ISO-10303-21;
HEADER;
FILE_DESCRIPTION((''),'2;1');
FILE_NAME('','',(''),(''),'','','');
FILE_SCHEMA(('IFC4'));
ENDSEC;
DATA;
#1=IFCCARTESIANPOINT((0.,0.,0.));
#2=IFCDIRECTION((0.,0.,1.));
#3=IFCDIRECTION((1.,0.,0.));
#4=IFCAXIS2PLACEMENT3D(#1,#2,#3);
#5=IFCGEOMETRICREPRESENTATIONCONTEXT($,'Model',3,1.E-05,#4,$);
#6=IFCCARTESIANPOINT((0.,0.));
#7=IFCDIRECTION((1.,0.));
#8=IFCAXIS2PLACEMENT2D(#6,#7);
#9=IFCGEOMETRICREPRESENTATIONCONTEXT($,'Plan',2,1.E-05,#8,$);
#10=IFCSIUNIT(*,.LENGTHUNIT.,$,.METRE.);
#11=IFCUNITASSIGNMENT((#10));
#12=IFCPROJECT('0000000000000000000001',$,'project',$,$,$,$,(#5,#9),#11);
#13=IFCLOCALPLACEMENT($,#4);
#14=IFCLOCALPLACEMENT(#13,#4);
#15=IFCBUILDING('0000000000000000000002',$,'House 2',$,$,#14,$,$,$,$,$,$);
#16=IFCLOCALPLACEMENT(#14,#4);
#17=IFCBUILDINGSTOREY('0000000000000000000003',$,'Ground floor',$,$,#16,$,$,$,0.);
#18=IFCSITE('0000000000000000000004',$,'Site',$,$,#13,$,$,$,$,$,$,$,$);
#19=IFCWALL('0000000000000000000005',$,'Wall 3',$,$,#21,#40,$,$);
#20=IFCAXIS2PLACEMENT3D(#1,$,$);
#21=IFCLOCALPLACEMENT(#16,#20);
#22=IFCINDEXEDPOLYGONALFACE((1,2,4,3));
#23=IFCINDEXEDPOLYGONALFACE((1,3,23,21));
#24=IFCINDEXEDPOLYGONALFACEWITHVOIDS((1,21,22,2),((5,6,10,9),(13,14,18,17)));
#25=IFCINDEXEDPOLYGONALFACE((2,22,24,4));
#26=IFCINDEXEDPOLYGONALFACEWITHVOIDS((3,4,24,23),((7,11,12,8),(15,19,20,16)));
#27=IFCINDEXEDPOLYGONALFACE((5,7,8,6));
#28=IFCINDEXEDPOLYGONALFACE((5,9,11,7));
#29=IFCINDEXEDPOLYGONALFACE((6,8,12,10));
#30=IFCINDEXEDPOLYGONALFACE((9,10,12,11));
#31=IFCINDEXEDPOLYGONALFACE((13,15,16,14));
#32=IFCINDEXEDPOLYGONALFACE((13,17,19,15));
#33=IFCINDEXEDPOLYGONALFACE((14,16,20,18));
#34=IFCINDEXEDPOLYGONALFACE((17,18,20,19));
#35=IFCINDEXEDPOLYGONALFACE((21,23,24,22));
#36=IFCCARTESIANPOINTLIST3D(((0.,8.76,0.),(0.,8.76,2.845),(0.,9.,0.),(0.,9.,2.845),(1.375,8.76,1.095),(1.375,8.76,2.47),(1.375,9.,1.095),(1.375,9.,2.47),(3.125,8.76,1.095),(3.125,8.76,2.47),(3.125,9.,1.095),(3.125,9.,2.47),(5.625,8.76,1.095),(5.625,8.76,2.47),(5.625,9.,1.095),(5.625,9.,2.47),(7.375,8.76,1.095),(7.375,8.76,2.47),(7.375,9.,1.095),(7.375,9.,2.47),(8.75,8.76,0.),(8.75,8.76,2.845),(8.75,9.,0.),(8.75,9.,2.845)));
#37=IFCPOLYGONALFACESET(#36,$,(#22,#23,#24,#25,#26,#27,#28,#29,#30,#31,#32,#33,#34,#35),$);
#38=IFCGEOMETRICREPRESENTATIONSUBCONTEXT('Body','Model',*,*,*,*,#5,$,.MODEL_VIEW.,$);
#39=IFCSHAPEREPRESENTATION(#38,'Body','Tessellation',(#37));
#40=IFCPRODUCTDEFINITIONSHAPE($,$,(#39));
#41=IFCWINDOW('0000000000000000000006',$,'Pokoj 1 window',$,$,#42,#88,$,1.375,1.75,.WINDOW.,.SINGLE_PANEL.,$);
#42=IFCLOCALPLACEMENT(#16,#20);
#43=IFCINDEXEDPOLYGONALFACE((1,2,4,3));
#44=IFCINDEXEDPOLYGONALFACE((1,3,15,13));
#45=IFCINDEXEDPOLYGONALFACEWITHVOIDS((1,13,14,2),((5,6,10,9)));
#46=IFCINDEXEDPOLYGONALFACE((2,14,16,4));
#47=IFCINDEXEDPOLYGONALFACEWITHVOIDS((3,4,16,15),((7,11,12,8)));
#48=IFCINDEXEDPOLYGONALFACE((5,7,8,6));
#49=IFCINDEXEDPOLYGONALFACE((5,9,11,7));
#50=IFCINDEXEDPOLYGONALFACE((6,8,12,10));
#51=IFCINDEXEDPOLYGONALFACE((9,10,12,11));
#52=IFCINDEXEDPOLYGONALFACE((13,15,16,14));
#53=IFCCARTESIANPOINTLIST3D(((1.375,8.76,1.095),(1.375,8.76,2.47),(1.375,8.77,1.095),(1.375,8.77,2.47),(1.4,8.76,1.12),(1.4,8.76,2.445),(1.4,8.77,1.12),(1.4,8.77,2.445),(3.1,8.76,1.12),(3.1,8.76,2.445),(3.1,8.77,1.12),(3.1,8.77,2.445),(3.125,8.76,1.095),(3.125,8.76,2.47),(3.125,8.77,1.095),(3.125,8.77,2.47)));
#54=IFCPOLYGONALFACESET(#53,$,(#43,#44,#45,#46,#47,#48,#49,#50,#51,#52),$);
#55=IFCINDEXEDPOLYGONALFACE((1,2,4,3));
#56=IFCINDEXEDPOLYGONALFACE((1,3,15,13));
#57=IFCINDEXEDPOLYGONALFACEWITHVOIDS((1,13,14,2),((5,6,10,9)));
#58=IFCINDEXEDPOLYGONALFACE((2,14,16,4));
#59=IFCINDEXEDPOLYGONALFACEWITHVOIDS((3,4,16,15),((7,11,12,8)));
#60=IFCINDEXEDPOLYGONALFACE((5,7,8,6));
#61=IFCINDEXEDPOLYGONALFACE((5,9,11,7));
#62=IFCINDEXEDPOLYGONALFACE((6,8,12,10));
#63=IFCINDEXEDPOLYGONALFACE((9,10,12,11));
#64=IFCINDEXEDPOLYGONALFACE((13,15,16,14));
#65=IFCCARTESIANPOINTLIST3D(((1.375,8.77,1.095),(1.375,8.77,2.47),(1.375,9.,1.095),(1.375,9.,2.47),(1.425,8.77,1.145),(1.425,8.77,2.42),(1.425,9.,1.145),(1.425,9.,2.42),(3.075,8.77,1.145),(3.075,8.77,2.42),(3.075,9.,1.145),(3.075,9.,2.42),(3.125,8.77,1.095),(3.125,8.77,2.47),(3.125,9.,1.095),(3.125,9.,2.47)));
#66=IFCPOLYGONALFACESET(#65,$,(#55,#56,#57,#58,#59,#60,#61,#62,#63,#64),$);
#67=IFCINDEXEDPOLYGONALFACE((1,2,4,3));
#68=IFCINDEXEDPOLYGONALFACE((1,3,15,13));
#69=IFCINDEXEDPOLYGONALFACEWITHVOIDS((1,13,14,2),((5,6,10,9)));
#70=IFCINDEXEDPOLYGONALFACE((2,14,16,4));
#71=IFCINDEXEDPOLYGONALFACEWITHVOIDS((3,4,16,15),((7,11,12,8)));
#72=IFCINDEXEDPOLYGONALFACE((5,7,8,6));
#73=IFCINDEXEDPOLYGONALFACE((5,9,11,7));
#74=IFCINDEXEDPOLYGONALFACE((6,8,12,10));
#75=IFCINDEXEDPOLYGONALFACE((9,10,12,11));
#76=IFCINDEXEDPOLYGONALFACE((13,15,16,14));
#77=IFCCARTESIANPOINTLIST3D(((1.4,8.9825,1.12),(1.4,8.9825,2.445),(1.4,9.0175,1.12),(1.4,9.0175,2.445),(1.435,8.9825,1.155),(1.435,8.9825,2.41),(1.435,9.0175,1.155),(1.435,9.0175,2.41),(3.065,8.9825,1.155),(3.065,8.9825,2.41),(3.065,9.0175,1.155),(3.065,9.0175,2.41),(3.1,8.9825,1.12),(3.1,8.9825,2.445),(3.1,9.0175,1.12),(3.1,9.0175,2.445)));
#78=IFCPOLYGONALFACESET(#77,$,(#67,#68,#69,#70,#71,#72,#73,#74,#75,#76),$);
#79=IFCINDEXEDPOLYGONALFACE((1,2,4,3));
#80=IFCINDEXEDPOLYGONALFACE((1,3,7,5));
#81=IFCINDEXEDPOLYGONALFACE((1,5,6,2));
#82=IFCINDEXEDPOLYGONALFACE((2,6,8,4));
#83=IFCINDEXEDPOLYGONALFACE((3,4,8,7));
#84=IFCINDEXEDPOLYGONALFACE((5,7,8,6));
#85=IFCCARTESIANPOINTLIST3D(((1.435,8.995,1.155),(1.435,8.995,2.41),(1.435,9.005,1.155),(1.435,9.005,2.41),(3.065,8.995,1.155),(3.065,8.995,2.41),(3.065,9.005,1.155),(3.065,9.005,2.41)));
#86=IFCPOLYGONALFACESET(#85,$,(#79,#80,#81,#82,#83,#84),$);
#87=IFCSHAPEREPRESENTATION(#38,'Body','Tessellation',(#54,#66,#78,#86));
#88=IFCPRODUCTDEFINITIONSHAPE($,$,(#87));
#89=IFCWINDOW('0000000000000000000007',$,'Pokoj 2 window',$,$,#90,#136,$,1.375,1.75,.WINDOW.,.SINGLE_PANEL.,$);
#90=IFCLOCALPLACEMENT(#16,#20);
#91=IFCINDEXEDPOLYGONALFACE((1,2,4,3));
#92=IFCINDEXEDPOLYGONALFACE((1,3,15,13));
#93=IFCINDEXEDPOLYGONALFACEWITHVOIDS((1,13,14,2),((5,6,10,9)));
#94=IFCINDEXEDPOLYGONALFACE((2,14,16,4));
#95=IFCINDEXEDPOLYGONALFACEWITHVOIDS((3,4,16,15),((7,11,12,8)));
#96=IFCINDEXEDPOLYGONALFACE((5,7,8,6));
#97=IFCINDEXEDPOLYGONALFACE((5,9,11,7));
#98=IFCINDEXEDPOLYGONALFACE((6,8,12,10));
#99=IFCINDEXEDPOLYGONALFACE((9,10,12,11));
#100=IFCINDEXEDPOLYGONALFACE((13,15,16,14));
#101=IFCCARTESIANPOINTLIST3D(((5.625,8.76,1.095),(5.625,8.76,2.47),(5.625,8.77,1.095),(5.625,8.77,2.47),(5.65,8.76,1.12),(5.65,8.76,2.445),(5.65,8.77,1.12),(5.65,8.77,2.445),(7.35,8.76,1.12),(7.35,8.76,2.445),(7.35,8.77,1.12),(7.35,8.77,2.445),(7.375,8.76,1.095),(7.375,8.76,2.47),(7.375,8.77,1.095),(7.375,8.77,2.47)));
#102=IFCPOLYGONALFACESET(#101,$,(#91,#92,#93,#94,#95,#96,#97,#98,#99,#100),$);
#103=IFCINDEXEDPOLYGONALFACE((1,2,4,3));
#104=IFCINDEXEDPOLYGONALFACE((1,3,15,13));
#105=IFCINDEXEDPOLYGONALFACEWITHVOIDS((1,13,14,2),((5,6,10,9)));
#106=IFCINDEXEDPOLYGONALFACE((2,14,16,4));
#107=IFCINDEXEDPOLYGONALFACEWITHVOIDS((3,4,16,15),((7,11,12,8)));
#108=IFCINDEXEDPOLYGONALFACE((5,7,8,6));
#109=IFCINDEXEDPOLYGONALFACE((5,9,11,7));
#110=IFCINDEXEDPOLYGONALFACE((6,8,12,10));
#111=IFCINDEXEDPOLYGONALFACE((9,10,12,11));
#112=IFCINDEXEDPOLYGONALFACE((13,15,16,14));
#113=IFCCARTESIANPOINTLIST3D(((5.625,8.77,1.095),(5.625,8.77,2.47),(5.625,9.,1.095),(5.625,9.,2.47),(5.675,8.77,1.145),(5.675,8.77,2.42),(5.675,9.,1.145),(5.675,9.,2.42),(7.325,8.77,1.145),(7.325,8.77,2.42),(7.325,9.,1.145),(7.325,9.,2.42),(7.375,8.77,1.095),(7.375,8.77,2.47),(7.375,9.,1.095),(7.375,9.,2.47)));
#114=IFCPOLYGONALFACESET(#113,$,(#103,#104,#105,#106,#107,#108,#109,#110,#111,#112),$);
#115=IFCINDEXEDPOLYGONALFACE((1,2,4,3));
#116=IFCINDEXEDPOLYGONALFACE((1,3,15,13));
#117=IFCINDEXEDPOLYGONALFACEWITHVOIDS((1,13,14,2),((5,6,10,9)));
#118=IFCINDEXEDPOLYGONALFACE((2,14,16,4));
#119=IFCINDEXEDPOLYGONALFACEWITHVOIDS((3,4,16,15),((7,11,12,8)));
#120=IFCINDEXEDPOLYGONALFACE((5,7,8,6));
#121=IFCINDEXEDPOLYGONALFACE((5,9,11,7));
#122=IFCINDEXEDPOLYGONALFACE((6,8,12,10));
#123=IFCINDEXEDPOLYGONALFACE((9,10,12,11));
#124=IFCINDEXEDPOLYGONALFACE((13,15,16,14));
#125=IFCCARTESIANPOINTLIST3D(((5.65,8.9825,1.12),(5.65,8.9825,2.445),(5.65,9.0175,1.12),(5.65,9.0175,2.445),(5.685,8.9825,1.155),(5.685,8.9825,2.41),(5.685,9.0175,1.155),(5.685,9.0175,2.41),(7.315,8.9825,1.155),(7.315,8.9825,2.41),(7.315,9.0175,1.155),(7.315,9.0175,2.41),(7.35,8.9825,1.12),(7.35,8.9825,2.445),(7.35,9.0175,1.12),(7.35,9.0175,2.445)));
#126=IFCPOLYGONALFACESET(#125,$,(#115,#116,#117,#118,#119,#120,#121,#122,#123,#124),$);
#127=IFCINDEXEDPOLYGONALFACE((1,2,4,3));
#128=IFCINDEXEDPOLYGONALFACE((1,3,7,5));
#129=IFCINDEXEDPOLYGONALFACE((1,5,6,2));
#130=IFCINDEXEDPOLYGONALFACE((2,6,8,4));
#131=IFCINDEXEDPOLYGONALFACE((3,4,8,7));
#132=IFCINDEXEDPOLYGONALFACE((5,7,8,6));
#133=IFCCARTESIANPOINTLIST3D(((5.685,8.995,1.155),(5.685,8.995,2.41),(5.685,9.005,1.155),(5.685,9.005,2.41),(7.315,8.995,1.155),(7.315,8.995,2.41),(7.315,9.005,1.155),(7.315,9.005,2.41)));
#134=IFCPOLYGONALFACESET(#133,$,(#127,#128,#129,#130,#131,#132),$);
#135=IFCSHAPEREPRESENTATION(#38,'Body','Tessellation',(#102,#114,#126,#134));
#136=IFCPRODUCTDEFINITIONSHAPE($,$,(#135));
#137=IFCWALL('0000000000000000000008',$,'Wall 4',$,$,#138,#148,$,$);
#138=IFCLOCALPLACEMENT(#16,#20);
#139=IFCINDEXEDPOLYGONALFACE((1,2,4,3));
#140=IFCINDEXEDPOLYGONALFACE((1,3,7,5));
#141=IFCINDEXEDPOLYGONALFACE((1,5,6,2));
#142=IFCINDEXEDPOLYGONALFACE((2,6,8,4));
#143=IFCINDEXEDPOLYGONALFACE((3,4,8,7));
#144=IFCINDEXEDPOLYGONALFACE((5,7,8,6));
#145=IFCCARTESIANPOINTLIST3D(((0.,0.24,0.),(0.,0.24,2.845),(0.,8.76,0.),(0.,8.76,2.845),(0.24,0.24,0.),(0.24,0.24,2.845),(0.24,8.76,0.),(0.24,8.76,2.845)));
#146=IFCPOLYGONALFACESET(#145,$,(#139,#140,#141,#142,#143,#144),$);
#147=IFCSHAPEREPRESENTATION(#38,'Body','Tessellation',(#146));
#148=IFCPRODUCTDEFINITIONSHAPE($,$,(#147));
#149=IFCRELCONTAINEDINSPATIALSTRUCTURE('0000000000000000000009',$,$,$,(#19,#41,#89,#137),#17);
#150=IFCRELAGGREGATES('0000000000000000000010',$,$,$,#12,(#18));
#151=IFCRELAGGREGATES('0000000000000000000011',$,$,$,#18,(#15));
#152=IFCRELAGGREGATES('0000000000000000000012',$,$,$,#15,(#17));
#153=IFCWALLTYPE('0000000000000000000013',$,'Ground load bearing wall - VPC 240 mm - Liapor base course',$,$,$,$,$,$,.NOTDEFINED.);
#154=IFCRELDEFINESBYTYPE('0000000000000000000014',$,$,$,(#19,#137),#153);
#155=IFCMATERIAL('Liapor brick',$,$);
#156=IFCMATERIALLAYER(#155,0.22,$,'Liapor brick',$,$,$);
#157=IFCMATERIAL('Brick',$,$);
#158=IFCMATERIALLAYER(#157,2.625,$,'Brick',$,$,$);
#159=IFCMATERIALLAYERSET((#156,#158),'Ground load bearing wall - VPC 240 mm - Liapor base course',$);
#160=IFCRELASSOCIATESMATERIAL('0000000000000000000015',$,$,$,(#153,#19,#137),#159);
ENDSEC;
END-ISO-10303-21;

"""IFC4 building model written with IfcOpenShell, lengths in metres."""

from ifc_helpers import new_model, entity, si_unit, frame, origin_with_axes, origin_2d_with_axis, place, context, subcontext, project, spatial, line, indexed_curve, outline, extrude, shape, material, layer, layer_set, layer_usage, type_object, element, fill, save


model = new_model("IFC4")

# Units and contexts
model_context = context("Model", 3, precision=1e-05, world=origin_with_axes())
plan_context = context("Plan", 2, precision=1e-05, world=origin_2d_with_axis())
body_context_1 = subcontext(model_context, "Body", "Model", "MODEL_VIEW")
body_context_2 = subcontext(plan_context, "Body", "Plan", "PLAN_VIEW")
ifc_project = project(units=[si_unit("LENGTHUNIT", "METRE")], contexts=[model_context, plan_context])

# Site, building, storey
site_placement = place(None, origin_with_axes())
site = spatial("IfcSite", under=ifc_project, at=site_placement, Name="Site")
building_placement = place(site_placement, origin_with_axes())
building = spatial("IfcBuilding", under=site, at=building_placement, Name="House 2")
storey_placement = place(building_placement, origin_with_axes())
storey = spatial("IfcBuildingStorey", under=building, at=storey_placement, Name="Ground floor", Elevation=0.0)

# Wall, openings, windows
ifc_material_1 = material(Name="Liapor brick")
ifc_layer_1 = layer(ifc_material_1, 0.22, Name="Liapor brick")
ifc_material_2 = material(Name="Brick")
ifc_layer_2 = layer(ifc_material_2, 2.625, Name="Brick")
ifc_layer_set_1 = layer_set([ifc_layer_1, ifc_layer_2], Name="Ground load bearing wall - VPC 240 mm - Liapor base course")
ifc_layer_usage_1 = layer_usage(ifc_layer_set_1, "AXIS3", "POSITIVE", 0.0)
wall_type_1 = type_object("IfcWallType", Name="Ground load bearing wall - VPC 240 mm - Liapor base course", PredefinedType="NOTDEFINED", material=ifc_layer_set_1)
wall_1_placement = place(storey_placement, frame((8.75, 9.0, 0.0), z_axis=(0.0, 0.0, 1.0), x_axis=(-1.0, 0.0, 0.0)))
wall_1 = element("IfcWall", 1, at=wall_1_placement, inside=storey, type_object=wall_type_1, material=ifc_layer_usage_1, Name="Wall 3", context=body_context_1, shape_type="SweptSolid", body=[
    extrude(outline(indexed_curve([(0.0, 0.0), (0.0, 0.24), (8.75, 0.24), (8.75, 0.0), (0.0, 0.0)], self_intersect=False)), origin_with_axes(), (0.0, 0.0, 1.0), 2.845),
])
opening_1_placement = place(wall_1_placement, frame((5.625, 0.0, 1.095), z_axis=(0.0, 0.0, 1.0), x_axis=(1.0, 0.0, 0.0)))
opening_1 = element("IfcOpeningElement", 2, at=opening_1_placement, cuts=wall_1, PredefinedType="OPENING", context=body_context_1, shape_type="SweptSolid", body=[
    extrude(outline(indexed_curve([(0.0, 0.0), (0.0, 0.34), (1.75, 0.34), (1.75, 0.0), (0.0, 0.0)], self_intersect=False)), frame((0.0, -0.05, 0.0), z_axis=(0.0, 0.0, 1.0), x_axis=(1.0, 0.0, 0.0)), (0.0, 0.0, 1.0), 1.375),
])
opening_2_placement = place(wall_1_placement, frame((1.375, 0.0, 1.095), z_axis=(0.0, 0.0, 1.0), x_axis=(1.0, 0.0, 0.0)))
opening_2 = element("IfcOpeningElement", 3, at=opening_2_placement, cuts=wall_1, PredefinedType="OPENING", context=body_context_1, shape_type="SweptSolid", body=[
    extrude(outline(indexed_curve([(0.0, 0.0), (0.0, 0.34), (1.75, 0.34), (1.75, 0.0), (0.0, 0.0)], self_intersect=False)), frame((0.0, -0.05, 0.0), z_axis=(0.0, 0.0, 1.0), x_axis=(1.0, 0.0, 0.0)), (0.0, 0.0, 1.0), 1.375),
])
window_1_placement = place(opening_1_placement, frame((0.0, 0.0, 0.0), z_axis=(0.0, 0.0, 1.0), x_axis=(1.0, 0.0, 0.0)))
window_1 = element("IfcWindow", 4, at=window_1_placement, inside=storey, Name="Pokoj 1 window", OverallHeight=1.375, OverallWidth=1.75, PartitioningType="SINGLE_PANEL", PredefinedType="WINDOW", shapes=[
    shape(body_context_1, "Body", "SweptSolid", [extrude(outline(indexed_curve([(0.0, 0.0), (1.75, 0.0), (1.75, 1.375), (0.0, 1.375)], segments=[line(1, 2, 3, 4, 1)]), holes=[indexed_curve([(0.025, 0.025), (1.725, 0.025), (1.725, 1.35), (0.025, 1.35)], segments=[line(1, 2, 3, 4, 1)])]), frame((0.0, 0.23, 0.0), z_axis=(0.0, -1.0, 0.0), x_axis=(1.0, 0.0, 0.0)), (0.0, 0.0, -1.0), 0.01), extrude(outline(indexed_curve([(0.0, 0.0), (1.75, 0.0), (1.75, 1.375), (0.0, 1.375)], segments=[line(1, 2, 3, 4, 1)]), holes=[indexed_curve([(0.05, 0.05), (1.7, 0.05), (1.7, 1.325), (0.05, 1.325)], segments=[line(1, 2, 3, 4, 1)])]), frame((0.0, 0.0, 0.0), z_axis=(0.0, -1.0, 0.0), x_axis=(1.0, 0.0, 0.0)), (0.0, 0.0, -1.0), 0.23), extrude(outline(indexed_curve([(0.0, 0.0), (1.7, 0.0), (1.7, 1.325), (0.0, 1.325)], segments=[line(1, 2, 3, 4, 1)]), holes=[indexed_curve([(0.035, 0.035), (1.665, 0.035), (1.665, 1.29), (0.035, 1.29)], segments=[line(1, 2, 3, 4, 1)])]), frame((0.025, -0.0175, 0.025), z_axis=(0.0, -1.0, 0.0), x_axis=(1.0, 0.0, 0.0)), (0.0, 0.0, -1.0), 0.035), extrude(outline(indexed_curve([(0.035, 0.035), (1.665, 0.035), (1.665, 1.29), (0.035, 1.29)], segments=[line(1, 2, 3, 4, 1)])), frame((0.025, -0.005, 0.025), z_axis=(0.0, -1.0, 0.0), x_axis=(1.0, 0.0, 0.0)), (0.0, 0.0, -1.0), 0.01)]),
    shape(body_context_2, "Body", "Curve2D", [entity("IfcIndexedPolyCurve", entity("IfcCartesianPointList2D", [[0.05, 0.0], [1.7, 0.0]])), entity("IfcIndexedPolyCurve", entity("IfcCartesianPointList2D", [[0.0, 0.24], [0.025, 0.24], [0.025, 0.23], [0.05, 0.23], [0.05, 0.0], [0.0, 0.0]]), [entity("IfcLineIndex", [1, 2, 3, 4, 5, 6, 1])]), entity("IfcIndexedPolyCurve", entity("IfcCartesianPointList2D", [[1.75, 0.24], [1.725, 0.24], [1.725, 0.23], [1.7, 0.23], [1.7, 0.0], [1.75, 0.0]]), [entity("IfcLineIndex", [1, 2, 3, 4, 5, 6, 1])]), entity("IfcIndexedPolyCurve", entity("IfcCartesianPointList2D", [[0.025, -0.0175], [0.06, -0.0175], [0.06, 0.0175], [0.025, 0.0175]]), [entity("IfcLineIndex", [1, 2, 3, 4, 1])]), entity("IfcIndexedPolyCurve", entity("IfcCartesianPointList2D", [[1.725, -0.0175], [1.69, -0.0175], [1.69, 0.0175], [1.725, 0.0175]]), [entity("IfcLineIndex", [1, 2, 3, 4, 1])]), entity("IfcIndexedPolyCurve", entity("IfcCartesianPointList2D", [[0.06, -0.0175], [1.69, -0.0175]])), entity("IfcIndexedPolyCurve", entity("IfcCartesianPointList2D", [[0.06, 0.0175], [1.69, 0.0175]])), entity("IfcIndexedPolyCurve", entity("IfcCartesianPointList2D", [[0.06, 0.0], [1.69, 0.0]]))]),
])
fill(opening_1, window_1)
window_2_placement = place(opening_2_placement, frame((0.0, 0.0, 0.0), z_axis=(0.0, 0.0, 1.0), x_axis=(1.0, 0.0, 0.0)))
window_2 = element("IfcWindow", 5, at=window_2_placement, inside=storey, Name="Pokoj 2 window", OverallHeight=1.375, OverallWidth=1.75, PartitioningType="SINGLE_PANEL", PredefinedType="WINDOW", shapes=[
    shape(body_context_1, "Body", "SweptSolid", [extrude(outline(indexed_curve([(0.0, 0.0), (1.75, 0.0), (1.75, 1.375), (0.0, 1.375)], segments=[line(1, 2, 3, 4, 1)]), holes=[indexed_curve([(0.025, 0.025), (1.725, 0.025), (1.725, 1.35), (0.025, 1.35)], segments=[line(1, 2, 3, 4, 1)])]), frame((0.0, 0.23, 0.0), z_axis=(0.0, -1.0, 0.0), x_axis=(1.0, 0.0, 0.0)), (0.0, 0.0, -1.0), 0.01), extrude(outline(indexed_curve([(0.0, 0.0), (1.75, 0.0), (1.75, 1.375), (0.0, 1.375)], segments=[line(1, 2, 3, 4, 1)]), holes=[indexed_curve([(0.05, 0.05), (1.7, 0.05), (1.7, 1.325), (0.05, 1.325)], segments=[line(1, 2, 3, 4, 1)])]), frame((0.0, 0.0, 0.0), z_axis=(0.0, -1.0, 0.0), x_axis=(1.0, 0.0, 0.0)), (0.0, 0.0, -1.0), 0.23), extrude(outline(indexed_curve([(0.0, 0.0), (1.7, 0.0), (1.7, 1.325), (0.0, 1.325)], segments=[line(1, 2, 3, 4, 1)]), holes=[indexed_curve([(0.035, 0.035), (1.665, 0.035), (1.665, 1.29), (0.035, 1.29)], segments=[line(1, 2, 3, 4, 1)])]), frame((0.025, -0.0175, 0.025), z_axis=(0.0, -1.0, 0.0), x_axis=(1.0, 0.0, 0.0)), (0.0, 0.0, -1.0), 0.035), extrude(outline(indexed_curve([(0.035, 0.035), (1.665, 0.035), (1.665, 1.29), (0.035, 1.29)], segments=[line(1, 2, 3, 4, 1)])), frame((0.025, -0.005, 0.025), z_axis=(0.0, -1.0, 0.0), x_axis=(1.0, 0.0, 0.0)), (0.0, 0.0, -1.0), 0.01)]),
    shape(body_context_2, "Body", "Curve2D", [entity("IfcIndexedPolyCurve", entity("IfcCartesianPointList2D", [[0.05, 0.0], [1.7, 0.0]])), entity("IfcIndexedPolyCurve", entity("IfcCartesianPointList2D", [[0.0, 0.24], [0.025, 0.24], [0.025, 0.23], [0.05, 0.23], [0.05, 0.0], [0.0, 0.0]]), [entity("IfcLineIndex", [1, 2, 3, 4, 5, 6, 1])]), entity("IfcIndexedPolyCurve", entity("IfcCartesianPointList2D", [[1.75, 0.24], [1.725, 0.24], [1.725, 0.23], [1.7, 0.23], [1.7, 0.0], [1.75, 0.0]]), [entity("IfcLineIndex", [1, 2, 3, 4, 5, 6, 1])]), entity("IfcIndexedPolyCurve", entity("IfcCartesianPointList2D", [[0.025, -0.0175], [0.06, -0.0175], [0.06, 0.0175], [0.025, 0.0175]]), [entity("IfcLineIndex", [1, 2, 3, 4, 1])]), entity("IfcIndexedPolyCurve", entity("IfcCartesianPointList2D", [[1.725, -0.0175], [1.69, -0.0175], [1.69, 0.0175], [1.725, 0.0175]]), [entity("IfcLineIndex", [1, 2, 3, 4, 1])]), entity("IfcIndexedPolyCurve", entity("IfcCartesianPointList2D", [[0.06, -0.0175], [1.69, -0.0175]])), entity("IfcIndexedPolyCurve", entity("IfcCartesianPointList2D", [[0.06, 0.0175], [1.69, 0.0175]])), entity("IfcIndexedPolyCurve", entity("IfcCartesianPointList2D", [[0.06, 0.0], [1.69, 0.0]]))]),
])
fill(opening_2, window_2)

# Wall
ifc_layer_usage_2 = layer_usage(ifc_layer_set_1, "AXIS3", "POSITIVE", 0.0)
wall_2_placement = place(storey_placement, frame((0.0, 8.76, 0.0), z_axis=(0.0, 0.0, 1.0), x_axis=(0.0, -1.0, 0.0)))
element("IfcWall", 6, at=wall_2_placement, inside=storey, type_object=wall_type_1, material=ifc_layer_usage_2, Name="Wall 4", context=body_context_1, shape_type="SweptSolid", body=[
    extrude(outline(indexed_curve([(0.0, 0.0), (0.0, 0.24), (8.52, 0.24), (8.52, 0.0), (0.0, 0.0)], self_intersect=False)), origin_with_axes(), (0.0, 0.0, 1.0), 2.845),
])

save(model, "model.ifc")
